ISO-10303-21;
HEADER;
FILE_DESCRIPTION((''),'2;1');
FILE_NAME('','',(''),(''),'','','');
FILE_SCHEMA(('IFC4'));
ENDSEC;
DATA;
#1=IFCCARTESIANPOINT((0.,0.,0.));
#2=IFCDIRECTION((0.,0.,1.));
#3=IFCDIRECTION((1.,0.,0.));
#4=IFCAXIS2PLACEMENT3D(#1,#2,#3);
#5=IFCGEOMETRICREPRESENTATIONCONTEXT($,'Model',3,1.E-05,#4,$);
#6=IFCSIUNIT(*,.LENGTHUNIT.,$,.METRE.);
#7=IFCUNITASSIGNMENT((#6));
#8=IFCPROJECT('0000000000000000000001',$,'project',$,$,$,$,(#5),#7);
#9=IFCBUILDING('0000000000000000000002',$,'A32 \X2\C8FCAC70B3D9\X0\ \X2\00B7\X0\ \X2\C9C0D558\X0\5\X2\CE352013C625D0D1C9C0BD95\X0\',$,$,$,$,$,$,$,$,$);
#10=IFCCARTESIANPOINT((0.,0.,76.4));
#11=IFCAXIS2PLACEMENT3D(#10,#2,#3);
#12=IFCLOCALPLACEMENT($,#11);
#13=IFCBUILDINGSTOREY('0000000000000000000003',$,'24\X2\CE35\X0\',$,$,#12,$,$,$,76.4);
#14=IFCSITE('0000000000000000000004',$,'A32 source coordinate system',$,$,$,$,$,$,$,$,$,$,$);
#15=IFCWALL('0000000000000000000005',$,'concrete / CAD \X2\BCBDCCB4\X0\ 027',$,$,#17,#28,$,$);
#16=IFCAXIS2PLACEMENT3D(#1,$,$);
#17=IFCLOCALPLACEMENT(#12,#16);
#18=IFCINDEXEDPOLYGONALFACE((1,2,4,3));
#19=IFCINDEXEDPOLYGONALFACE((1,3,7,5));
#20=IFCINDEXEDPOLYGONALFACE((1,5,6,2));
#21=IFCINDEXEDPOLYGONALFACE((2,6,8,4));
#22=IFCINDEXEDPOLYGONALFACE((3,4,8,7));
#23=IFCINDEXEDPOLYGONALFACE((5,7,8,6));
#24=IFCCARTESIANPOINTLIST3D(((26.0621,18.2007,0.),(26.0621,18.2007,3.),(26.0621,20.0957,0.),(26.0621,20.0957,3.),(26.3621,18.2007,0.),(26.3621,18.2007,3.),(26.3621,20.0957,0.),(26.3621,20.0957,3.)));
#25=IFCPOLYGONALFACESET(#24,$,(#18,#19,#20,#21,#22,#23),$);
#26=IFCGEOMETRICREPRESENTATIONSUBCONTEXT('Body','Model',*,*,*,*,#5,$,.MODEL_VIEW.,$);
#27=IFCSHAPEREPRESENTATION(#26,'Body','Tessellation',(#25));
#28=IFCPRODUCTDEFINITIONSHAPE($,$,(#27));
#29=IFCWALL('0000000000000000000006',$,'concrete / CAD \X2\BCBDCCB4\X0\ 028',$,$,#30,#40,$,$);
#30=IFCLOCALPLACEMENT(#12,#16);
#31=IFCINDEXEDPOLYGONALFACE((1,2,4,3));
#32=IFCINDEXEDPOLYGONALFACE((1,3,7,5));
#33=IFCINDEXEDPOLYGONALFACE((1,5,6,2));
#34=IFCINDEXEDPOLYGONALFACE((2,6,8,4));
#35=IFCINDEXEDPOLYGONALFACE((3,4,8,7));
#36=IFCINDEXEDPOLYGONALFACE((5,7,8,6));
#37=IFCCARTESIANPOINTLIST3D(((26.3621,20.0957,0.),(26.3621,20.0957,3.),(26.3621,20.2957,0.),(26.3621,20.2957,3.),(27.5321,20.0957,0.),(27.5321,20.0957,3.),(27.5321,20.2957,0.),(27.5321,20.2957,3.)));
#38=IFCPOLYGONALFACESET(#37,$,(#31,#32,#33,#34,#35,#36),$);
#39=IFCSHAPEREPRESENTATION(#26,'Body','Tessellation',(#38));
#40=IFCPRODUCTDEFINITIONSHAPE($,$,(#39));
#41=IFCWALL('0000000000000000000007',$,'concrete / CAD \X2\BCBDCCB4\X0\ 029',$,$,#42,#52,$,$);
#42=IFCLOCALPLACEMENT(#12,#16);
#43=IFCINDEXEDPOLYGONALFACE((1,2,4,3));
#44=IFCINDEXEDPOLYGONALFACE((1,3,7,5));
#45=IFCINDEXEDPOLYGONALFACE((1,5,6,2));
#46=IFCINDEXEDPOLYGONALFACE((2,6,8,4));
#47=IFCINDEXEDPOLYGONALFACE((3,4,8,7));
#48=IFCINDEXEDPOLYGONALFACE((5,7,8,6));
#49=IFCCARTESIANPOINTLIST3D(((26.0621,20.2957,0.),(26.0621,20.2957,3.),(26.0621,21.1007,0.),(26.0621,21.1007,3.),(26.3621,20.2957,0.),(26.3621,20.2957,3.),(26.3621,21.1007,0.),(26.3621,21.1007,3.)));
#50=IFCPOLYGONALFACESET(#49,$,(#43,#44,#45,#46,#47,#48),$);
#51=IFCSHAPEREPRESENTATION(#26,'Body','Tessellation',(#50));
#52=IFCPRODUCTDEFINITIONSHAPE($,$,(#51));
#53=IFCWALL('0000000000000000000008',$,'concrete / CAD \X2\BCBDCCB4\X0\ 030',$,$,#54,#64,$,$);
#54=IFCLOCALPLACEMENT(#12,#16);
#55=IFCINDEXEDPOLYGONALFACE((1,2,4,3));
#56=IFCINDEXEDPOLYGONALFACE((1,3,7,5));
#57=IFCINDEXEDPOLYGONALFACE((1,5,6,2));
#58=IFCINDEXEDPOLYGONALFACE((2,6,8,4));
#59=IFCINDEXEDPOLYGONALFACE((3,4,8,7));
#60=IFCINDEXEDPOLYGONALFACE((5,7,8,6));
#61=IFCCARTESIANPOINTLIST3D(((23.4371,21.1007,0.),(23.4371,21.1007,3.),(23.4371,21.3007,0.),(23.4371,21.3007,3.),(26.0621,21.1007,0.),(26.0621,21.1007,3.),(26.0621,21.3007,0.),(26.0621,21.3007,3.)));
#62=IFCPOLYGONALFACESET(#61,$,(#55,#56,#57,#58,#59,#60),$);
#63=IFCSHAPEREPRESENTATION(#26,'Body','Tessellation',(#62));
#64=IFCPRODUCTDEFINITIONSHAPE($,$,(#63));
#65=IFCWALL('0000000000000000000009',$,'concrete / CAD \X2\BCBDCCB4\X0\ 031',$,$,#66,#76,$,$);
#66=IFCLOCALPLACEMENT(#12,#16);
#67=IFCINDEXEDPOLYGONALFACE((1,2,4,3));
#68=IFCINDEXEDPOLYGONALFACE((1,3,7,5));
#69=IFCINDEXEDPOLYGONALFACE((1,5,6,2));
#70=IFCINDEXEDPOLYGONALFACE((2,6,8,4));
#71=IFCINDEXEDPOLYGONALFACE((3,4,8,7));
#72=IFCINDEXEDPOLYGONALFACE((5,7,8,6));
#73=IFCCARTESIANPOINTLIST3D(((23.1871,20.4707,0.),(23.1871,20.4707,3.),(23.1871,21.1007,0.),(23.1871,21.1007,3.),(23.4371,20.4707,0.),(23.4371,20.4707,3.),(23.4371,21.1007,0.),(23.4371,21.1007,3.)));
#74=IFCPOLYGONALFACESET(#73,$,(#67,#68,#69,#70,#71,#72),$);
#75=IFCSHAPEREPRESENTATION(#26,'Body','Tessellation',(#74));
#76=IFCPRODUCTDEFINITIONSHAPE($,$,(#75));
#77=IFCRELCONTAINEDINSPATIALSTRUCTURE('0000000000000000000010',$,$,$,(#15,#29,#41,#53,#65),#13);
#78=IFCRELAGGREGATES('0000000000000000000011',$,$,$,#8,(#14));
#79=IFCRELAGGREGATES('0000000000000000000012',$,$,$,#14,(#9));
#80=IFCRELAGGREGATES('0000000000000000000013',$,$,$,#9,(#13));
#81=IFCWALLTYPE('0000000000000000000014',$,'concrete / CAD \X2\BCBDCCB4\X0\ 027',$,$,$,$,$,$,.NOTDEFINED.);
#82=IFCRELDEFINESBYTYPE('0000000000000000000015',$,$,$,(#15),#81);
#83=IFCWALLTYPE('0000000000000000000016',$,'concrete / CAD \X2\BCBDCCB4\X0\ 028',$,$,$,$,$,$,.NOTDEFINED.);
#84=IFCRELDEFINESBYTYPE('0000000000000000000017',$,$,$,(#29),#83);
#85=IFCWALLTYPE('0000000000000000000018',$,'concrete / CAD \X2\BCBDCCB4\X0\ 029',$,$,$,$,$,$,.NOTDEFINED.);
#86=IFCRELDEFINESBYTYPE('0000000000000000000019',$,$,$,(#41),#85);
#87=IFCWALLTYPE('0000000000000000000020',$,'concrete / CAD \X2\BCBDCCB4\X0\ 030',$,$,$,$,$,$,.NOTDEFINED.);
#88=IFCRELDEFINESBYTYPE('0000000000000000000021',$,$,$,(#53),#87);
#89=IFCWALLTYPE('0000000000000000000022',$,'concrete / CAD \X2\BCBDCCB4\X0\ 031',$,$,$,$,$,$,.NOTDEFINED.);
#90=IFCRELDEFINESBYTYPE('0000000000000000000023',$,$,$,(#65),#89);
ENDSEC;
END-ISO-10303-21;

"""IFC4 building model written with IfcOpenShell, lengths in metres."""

from ifc_helpers import new_model, si_unit, frame, origin, origin_with_axes, place, context, subcontext, project, spatial, polyline, outline, extrude, source, transform, mapped, type_object, type_shapes, element, save


model = new_model("IFC4")

# Units and contexts
model_context = context("Model", 3, precision=1e-05, world=origin_with_axes())
body_context = subcontext(model_context, "Body", "Model", "MODEL_VIEW")
ifc_project = project(units=[si_unit("LENGTHUNIT", "METRE")], contexts=[model_context])

# Site, building, storey
site = spatial("IfcSite", under=ifc_project, Name="A32 source coordinate system")
building = spatial("IfcBuilding", under=site, Name="A32 주거동 · 지하5층–옥탑지붕")
storey_placement = place(None, frame((0.0, 0.0, 76.4), z_axis=(0.0, 0.0, 1.0), x_axis=(1.0, 0.0, 0.0)))
storey = spatial("IfcBuildingStorey", under=building, at=storey_placement, Name="24층", Elevation=76.4)

# Walls
wall_type_1 = type_object("IfcWallType", Name="concrete / CAD 벽체 027", PredefinedType="NOTDEFINED")
shared_shape_1 = source(origin(), body_context, "Body", "SweptSolid", [
    extrude(outline(polyline([(26.3621, 18.2007), (26.0621, 18.2007), (26.0621, 20.0957), (26.3621, 20.0957), (26.3621, 18.2007)])), origin(), (0.0, 0.0, 1.0), 3.0),
])
type_shapes(wall_type_1, [shared_shape_1])
wall_1_placement = place(storey_placement, origin_with_axes())
element("IfcWall", 1, at=wall_1_placement, inside=storey, type_object=wall_type_1, Name="concrete / CAD 벽체 027", context=body_context, shape_type="MappedRepresentation", body=[
    mapped(shared_shape_1, transform((0.0, 0.0, 0.0), scale=1.0)),
])
wall_type_2 = type_object("IfcWallType", Name="concrete / CAD 벽체 028", PredefinedType="NOTDEFINED")
shared_shape_2 = source(origin(), body_context, "Body", "SweptSolid", [
    extrude(outline(polyline([(26.3621, 20.0957), (26.3621, 20.2957), (27.5321, 20.2957), (27.5321, 20.0957), (26.3621, 20.0957)])), origin(), (0.0, 0.0, 1.0), 3.0),
])
type_shapes(wall_type_2, [shared_shape_2])
wall_2_placement = place(storey_placement, origin_with_axes())
element("IfcWall", 2, at=wall_2_placement, inside=storey, type_object=wall_type_2, Name="concrete / CAD 벽체 028", context=body_context, shape_type="MappedRepresentation", body=[
    mapped(shared_shape_2, transform((0.0, 0.0, 0.0), scale=1.0)),
])
wall_type_3 = type_object("IfcWallType", Name="concrete / CAD 벽체 029", PredefinedType="NOTDEFINED")
shared_shape_3 = source(origin(), body_context, "Body", "SweptSolid", [
    extrude(outline(polyline([(26.3621, 20.2957), (26.0621, 20.2957), (26.0621, 21.1007), (26.3621, 21.1007), (26.3621, 20.2957)])), origin(), (0.0, 0.0, 1.0), 3.0),
])
type_shapes(wall_type_3, [shared_shape_3])
wall_3_placement = place(storey_placement, origin_with_axes())
element("IfcWall", 3, at=wall_3_placement, inside=storey, type_object=wall_type_3, Name="concrete / CAD 벽체 029", context=body_context, shape_type="MappedRepresentation", body=[
    mapped(shared_shape_3, transform((0.0, 0.0, 0.0), scale=1.0)),
])
wall_type_4 = type_object("IfcWallType", Name="concrete / CAD 벽체 030", PredefinedType="NOTDEFINED")
shared_shape_4 = source(origin(), body_context, "Body", "SweptSolid", [
    extrude(outline(polyline([(26.0621, 21.3007), (26.0621, 21.1007), (23.4371, 21.1007), (23.4371, 21.3007), (26.0621, 21.3007)])), origin(), (0.0, 0.0, 1.0), 3.0),
])
type_shapes(wall_type_4, [shared_shape_4])
wall_4_placement = place(storey_placement, origin_with_axes())
element("IfcWall", 4, at=wall_4_placement, inside=storey, type_object=wall_type_4, Name="concrete / CAD 벽체 030", context=body_context, shape_type="MappedRepresentation", body=[
    mapped(shared_shape_4, transform((0.0, 0.0, 0.0), scale=1.0)),
])
wall_type_5 = type_object("IfcWallType", Name="concrete / CAD 벽체 031", PredefinedType="NOTDEFINED")
shared_shape_5 = source(origin(), body_context, "Body", "SweptSolid", [
    extrude(outline(polyline([(23.1871, 21.1007), (23.4371, 21.1007), (23.4371, 20.4707), (23.1871, 20.4707), (23.1871, 21.1007)])), origin(), (0.0, 0.0, 1.0), 3.0),
])
type_shapes(wall_type_5, [shared_shape_5])
wall_5_placement = place(storey_placement, origin_with_axes())
element("IfcWall", 5, at=wall_5_placement, inside=storey, type_object=wall_type_5, Name="concrete / CAD 벽체 031", context=body_context, shape_type="MappedRepresentation", body=[
    mapped(shared_shape_5, transform((0.0, 0.0, 0.0), scale=1.0)),
])

save(model, "model.ifc")
